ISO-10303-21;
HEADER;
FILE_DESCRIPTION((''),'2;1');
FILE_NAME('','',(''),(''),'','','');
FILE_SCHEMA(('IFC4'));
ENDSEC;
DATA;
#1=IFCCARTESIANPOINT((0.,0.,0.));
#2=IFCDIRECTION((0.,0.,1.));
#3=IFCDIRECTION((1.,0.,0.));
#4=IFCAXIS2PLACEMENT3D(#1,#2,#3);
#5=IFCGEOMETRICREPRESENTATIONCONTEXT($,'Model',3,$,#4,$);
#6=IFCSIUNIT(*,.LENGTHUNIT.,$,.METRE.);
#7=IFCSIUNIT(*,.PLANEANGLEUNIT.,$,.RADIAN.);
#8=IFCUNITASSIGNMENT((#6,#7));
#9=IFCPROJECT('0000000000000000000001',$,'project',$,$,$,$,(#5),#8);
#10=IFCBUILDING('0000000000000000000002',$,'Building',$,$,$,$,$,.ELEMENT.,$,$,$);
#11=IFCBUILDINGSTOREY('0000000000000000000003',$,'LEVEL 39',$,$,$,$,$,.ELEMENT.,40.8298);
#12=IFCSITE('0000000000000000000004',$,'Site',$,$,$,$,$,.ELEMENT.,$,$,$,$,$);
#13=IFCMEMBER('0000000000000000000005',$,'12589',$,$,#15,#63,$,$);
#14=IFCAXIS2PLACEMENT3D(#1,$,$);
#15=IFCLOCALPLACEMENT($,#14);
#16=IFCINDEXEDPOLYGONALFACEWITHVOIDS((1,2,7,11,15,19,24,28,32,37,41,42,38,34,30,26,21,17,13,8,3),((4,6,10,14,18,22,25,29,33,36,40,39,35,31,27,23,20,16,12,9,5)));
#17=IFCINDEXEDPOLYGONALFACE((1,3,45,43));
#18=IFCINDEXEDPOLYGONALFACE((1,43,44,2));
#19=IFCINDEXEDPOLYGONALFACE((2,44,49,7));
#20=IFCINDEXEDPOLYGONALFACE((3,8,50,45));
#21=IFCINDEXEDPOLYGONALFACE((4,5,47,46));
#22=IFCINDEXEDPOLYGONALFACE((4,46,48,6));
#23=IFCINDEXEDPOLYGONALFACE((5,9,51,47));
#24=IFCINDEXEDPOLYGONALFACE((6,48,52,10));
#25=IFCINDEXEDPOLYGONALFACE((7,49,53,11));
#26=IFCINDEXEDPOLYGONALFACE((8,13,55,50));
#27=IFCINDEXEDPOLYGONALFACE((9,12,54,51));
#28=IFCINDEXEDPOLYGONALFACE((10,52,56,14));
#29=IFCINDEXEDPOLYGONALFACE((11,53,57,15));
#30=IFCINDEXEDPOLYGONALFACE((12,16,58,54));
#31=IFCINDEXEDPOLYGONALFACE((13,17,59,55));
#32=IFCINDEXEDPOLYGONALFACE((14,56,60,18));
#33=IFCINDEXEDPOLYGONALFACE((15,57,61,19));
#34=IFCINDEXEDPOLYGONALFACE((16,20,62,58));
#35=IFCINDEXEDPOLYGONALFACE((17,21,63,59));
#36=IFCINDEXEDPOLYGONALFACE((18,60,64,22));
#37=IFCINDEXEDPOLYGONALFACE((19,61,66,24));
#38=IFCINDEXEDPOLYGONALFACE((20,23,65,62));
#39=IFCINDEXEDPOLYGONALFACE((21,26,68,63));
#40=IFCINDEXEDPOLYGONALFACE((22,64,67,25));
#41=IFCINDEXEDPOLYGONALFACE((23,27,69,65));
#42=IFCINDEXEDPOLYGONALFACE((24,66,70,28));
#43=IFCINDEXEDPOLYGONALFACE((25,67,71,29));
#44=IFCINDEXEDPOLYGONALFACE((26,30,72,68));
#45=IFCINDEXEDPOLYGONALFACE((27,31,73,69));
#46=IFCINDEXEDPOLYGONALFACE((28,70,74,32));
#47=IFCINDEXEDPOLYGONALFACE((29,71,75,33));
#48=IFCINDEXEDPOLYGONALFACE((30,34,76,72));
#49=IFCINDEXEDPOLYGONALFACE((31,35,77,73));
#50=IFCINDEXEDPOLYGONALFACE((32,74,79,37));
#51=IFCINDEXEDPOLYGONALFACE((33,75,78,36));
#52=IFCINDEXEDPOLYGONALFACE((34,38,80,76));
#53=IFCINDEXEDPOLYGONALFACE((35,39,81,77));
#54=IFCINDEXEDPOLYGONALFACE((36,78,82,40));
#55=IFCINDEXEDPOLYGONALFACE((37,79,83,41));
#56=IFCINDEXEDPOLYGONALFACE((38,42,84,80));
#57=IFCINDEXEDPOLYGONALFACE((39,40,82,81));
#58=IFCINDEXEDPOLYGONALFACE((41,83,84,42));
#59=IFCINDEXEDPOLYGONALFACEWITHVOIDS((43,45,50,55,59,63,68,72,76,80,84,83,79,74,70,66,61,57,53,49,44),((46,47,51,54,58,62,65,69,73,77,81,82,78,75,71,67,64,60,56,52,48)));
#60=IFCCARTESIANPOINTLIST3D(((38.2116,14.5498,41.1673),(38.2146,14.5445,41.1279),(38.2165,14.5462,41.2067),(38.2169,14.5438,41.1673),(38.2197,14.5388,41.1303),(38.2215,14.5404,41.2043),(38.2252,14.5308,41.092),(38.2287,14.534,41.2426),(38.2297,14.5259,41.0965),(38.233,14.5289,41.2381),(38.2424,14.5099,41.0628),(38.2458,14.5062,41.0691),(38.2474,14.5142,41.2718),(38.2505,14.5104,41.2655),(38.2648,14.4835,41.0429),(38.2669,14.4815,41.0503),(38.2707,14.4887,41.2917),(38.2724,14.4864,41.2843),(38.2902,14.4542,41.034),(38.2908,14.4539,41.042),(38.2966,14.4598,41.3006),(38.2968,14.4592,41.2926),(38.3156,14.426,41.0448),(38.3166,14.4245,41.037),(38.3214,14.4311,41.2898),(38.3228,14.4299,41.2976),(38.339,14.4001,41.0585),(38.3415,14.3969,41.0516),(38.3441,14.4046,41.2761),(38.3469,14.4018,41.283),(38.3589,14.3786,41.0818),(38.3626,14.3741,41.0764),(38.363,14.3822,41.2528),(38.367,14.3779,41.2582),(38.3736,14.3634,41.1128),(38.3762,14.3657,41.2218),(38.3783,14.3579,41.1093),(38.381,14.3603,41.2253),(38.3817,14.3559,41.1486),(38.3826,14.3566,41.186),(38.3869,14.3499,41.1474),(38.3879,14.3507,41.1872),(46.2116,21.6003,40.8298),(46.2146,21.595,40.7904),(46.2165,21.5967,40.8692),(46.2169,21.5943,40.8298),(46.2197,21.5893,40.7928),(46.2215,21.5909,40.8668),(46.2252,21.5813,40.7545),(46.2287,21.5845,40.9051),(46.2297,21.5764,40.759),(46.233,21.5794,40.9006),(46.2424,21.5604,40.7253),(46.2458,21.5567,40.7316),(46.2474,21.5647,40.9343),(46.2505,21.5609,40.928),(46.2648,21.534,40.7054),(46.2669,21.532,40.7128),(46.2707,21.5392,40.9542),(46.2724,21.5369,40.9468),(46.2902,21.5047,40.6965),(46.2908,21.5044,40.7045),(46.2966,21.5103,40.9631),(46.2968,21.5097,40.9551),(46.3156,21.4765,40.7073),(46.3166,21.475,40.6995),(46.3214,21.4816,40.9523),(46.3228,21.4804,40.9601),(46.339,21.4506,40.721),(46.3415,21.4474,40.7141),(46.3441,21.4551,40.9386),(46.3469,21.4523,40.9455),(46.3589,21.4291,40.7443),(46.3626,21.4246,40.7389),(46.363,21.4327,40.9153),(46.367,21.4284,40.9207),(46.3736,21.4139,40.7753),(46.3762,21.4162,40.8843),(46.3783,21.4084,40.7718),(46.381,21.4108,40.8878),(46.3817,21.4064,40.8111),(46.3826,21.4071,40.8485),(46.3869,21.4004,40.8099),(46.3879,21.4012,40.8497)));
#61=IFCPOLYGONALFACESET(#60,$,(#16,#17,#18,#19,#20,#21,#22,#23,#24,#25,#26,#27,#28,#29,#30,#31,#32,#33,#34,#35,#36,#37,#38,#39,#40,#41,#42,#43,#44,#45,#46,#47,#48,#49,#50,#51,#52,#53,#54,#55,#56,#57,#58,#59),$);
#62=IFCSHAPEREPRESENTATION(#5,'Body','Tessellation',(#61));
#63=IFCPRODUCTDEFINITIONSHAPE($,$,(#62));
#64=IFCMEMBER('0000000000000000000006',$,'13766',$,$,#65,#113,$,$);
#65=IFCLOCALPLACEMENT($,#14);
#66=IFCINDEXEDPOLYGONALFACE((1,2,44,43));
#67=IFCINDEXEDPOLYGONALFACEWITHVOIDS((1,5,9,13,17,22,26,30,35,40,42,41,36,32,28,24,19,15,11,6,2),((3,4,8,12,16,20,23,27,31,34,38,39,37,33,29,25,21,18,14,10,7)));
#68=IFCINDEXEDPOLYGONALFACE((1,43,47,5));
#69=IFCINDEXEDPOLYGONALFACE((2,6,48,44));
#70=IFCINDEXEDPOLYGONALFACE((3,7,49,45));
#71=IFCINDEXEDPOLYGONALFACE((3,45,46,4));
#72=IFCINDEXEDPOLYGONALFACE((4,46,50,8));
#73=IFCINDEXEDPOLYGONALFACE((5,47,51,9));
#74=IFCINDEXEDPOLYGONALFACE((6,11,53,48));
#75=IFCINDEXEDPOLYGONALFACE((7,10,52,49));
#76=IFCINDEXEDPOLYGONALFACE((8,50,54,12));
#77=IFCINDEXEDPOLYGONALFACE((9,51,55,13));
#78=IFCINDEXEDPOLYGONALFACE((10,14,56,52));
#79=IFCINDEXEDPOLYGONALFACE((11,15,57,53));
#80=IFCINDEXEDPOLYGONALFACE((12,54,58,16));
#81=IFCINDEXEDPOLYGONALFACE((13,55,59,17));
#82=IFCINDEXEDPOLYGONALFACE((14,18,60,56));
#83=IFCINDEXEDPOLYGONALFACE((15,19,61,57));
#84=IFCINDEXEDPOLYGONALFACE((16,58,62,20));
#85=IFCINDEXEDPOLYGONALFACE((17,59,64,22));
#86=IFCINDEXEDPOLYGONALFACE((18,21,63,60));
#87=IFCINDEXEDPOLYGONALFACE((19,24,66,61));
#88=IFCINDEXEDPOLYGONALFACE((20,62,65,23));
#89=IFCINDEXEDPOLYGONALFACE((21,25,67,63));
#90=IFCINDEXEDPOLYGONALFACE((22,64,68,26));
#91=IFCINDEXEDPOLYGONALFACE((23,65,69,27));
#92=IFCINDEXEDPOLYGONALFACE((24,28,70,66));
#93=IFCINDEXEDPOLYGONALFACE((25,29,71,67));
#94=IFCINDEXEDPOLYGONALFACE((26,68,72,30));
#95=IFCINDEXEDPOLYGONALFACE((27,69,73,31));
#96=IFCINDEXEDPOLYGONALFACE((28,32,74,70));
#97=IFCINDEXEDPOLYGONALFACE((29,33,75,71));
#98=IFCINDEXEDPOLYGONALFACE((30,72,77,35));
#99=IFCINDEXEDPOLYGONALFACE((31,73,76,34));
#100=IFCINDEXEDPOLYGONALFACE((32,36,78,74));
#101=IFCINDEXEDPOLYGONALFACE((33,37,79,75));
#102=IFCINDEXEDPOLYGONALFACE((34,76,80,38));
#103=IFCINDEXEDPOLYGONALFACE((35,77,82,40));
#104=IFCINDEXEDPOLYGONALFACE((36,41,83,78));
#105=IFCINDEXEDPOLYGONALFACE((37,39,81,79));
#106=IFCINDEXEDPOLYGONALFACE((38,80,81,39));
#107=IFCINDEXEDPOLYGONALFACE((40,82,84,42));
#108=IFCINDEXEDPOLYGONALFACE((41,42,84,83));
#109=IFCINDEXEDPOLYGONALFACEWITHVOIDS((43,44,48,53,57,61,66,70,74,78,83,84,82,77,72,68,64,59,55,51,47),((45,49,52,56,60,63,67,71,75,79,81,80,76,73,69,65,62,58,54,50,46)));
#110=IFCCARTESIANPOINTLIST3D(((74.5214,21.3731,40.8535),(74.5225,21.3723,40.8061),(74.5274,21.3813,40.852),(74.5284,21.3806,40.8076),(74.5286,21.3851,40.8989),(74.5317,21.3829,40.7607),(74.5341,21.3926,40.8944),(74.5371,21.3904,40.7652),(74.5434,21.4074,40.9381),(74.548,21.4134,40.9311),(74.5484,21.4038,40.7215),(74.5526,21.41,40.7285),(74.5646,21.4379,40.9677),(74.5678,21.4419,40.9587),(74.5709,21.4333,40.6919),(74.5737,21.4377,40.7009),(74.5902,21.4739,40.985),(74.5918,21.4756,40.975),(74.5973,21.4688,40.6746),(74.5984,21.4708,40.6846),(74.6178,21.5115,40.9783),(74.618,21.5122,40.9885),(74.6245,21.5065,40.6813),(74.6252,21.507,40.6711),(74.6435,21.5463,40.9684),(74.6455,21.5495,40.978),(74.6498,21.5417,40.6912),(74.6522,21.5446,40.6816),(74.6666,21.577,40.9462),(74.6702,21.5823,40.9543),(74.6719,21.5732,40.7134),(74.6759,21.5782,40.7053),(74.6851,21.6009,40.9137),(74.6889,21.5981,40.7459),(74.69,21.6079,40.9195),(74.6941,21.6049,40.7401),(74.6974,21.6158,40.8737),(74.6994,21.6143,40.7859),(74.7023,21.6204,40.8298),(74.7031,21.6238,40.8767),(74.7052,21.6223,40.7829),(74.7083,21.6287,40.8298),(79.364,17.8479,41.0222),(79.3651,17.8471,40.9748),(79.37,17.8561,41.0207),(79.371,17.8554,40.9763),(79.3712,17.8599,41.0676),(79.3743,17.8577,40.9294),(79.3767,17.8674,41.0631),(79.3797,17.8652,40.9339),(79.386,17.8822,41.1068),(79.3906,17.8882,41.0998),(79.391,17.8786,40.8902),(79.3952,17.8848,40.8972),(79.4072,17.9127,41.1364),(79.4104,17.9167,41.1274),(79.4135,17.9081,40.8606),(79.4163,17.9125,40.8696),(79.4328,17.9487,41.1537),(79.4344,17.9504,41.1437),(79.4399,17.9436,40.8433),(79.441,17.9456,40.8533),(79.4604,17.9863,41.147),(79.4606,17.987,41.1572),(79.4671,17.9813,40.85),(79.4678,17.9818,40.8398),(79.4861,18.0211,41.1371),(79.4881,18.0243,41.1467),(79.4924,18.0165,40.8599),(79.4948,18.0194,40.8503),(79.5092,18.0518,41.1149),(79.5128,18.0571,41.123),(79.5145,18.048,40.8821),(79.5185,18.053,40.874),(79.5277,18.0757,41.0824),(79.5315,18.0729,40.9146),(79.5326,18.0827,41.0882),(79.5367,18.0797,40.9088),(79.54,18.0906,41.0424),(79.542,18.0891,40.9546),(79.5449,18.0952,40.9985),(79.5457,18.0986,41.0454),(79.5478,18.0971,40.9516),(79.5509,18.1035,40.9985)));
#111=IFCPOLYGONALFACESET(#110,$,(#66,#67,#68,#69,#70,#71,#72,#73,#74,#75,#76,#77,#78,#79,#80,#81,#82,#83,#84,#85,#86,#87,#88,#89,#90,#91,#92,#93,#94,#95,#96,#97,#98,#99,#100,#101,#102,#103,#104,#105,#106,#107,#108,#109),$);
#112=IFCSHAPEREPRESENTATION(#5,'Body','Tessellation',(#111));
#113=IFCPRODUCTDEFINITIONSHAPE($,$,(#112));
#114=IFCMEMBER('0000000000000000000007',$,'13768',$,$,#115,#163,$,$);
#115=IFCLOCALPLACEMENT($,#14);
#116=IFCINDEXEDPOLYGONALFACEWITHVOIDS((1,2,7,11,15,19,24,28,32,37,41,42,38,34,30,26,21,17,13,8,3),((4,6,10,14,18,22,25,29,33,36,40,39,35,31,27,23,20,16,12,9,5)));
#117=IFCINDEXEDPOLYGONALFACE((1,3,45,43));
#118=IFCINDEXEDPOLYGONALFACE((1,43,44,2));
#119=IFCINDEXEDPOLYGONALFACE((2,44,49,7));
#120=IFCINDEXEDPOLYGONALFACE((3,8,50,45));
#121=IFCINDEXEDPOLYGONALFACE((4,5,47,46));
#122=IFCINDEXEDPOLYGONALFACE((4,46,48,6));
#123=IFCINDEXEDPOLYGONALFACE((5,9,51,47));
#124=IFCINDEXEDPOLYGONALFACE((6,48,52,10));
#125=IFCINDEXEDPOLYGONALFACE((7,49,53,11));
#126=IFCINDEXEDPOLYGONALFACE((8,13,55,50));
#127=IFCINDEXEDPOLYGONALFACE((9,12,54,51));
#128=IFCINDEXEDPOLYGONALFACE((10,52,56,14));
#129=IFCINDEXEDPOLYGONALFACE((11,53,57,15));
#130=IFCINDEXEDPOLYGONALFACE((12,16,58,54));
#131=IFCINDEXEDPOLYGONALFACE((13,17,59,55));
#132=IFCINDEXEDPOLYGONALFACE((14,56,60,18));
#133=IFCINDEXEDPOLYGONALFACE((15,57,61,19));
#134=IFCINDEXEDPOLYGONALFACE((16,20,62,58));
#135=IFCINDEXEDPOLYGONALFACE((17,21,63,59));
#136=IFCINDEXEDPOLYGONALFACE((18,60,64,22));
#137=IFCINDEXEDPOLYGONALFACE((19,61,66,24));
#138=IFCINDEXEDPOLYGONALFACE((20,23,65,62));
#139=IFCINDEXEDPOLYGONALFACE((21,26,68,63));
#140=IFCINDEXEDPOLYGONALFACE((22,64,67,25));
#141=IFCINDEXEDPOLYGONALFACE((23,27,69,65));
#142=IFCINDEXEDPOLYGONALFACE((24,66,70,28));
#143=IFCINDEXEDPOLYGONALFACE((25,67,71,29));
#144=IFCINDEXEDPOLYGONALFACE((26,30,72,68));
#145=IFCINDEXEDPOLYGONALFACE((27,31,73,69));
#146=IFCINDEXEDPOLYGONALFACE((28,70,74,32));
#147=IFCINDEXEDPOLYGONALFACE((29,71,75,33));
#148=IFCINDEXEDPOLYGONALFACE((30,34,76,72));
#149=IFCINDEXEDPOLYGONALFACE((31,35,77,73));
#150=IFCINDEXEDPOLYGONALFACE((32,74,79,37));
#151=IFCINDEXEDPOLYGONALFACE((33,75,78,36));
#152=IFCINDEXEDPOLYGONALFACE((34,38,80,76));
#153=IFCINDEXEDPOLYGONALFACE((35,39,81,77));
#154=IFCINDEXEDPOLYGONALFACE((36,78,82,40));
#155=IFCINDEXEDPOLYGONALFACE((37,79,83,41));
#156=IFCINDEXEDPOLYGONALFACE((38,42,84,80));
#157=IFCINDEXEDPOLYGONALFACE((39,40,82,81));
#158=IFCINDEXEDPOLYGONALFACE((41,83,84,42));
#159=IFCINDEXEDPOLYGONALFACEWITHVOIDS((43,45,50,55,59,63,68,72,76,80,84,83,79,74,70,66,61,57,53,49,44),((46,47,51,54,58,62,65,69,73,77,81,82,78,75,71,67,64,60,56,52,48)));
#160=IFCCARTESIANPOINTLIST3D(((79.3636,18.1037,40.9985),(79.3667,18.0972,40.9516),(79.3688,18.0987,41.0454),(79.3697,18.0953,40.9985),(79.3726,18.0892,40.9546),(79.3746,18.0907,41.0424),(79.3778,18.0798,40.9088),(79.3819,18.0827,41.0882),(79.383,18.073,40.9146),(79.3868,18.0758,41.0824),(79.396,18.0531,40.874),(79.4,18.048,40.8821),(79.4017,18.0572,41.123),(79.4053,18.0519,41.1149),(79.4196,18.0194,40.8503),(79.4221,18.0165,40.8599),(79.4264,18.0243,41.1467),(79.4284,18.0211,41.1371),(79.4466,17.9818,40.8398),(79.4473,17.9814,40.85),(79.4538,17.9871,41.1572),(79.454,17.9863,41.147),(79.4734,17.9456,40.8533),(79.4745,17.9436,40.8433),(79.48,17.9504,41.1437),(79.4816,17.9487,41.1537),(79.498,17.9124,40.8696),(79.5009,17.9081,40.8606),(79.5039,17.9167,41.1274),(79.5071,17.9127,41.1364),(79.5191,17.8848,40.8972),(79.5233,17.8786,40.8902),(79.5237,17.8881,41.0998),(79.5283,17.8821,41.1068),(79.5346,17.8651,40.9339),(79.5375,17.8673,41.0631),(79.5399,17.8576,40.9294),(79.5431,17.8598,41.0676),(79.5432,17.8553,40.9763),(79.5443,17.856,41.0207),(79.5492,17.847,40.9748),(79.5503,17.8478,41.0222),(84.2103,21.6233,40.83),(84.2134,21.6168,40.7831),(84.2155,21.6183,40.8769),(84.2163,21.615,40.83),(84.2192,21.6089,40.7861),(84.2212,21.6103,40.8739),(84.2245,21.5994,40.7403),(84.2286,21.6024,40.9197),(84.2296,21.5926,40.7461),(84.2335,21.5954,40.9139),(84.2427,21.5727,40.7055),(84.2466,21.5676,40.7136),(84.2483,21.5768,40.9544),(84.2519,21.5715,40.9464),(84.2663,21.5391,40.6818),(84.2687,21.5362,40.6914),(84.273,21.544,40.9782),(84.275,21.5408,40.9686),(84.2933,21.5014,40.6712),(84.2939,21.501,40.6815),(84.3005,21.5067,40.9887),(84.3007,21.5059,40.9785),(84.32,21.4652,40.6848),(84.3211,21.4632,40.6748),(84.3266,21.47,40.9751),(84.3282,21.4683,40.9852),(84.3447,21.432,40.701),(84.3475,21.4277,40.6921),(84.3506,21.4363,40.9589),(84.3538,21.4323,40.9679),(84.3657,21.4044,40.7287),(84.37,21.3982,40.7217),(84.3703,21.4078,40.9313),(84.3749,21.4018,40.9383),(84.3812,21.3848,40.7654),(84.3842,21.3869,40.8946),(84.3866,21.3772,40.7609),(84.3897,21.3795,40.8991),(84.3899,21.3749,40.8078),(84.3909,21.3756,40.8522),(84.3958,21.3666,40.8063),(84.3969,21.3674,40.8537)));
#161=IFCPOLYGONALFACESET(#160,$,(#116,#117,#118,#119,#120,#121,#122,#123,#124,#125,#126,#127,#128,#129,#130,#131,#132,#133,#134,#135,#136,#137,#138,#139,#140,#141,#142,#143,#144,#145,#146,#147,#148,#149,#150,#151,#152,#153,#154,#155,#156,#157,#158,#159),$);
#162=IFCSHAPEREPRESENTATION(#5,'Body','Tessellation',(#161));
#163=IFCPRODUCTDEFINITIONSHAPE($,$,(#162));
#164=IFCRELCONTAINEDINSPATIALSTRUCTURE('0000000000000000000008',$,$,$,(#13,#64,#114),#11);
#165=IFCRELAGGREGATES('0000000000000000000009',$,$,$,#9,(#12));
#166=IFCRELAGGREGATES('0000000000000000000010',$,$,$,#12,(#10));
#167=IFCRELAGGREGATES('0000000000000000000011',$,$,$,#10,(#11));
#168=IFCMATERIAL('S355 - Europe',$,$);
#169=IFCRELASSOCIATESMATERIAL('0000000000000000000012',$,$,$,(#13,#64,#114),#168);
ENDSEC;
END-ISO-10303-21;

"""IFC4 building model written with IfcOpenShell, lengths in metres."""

from ifc_helpers import new_model, si_unit, frame, origin_with_axes, origin_2d_with_axis, place, context, project, spatial, hollow_circle, extrude, material, material_profile, profile_set, profile_usage, element, save


model = new_model("IFC4")

# Units and contexts
model_context = context("Model", 3, world=origin_with_axes())
ifc_project = project(units=[si_unit("LENGTHUNIT", "METRE"), si_unit("PLANEANGLEUNIT", "RADIAN")], contexts=[model_context])

# Site, building, storey
site = spatial("IfcSite", under=ifc_project, Name="Site", CompositionType="ELEMENT")
building = spatial("IfcBuilding", under=site, Name="Building", CompositionType="ELEMENT")
storey = spatial("IfcBuildingStorey", under=building, Name="LEVEL 39", CompositionType="ELEMENT", Elevation=40.8298)

# Shared definitions
ifc_material = material(Name="S355 - Europe")

# Members
ifc_material_profile_1 = material_profile(ifc_material, hollow_circle(Radius=0.1337, WallThickness=0.008, at=origin_2d_with_axis()))
ifc_profile_set_1 = profile_set([ifc_material_profile_1])
ifc_profile_usage_1 = profile_usage(ifc_profile_set_1, cardinal=10)
member_1_placement = place(None, frame((38.3, 14.4495, 41.1673), z_axis=(0.749849, 0.660852, -0.031634), x_axis=(-0.661183, 0.750225, 0.0)))
element("IfcMember", 1, at=member_1_placement, inside=storey, material=ifc_profile_usage_1, Name="12589", context=model_context, shape_type="SweptSolid", body=[
    extrude(hollow_circle(Radius=0.1337, WallThickness=0.008, at=origin_2d_with_axis()), origin_with_axes(), (0.0, 0.0, 1.0), 10.6688),
])
ifc_material_profile_2 = material_profile(ifc_material, hollow_circle(Radius=0.1593, WallThickness=0.0103, at=origin_2d_with_axis()))
ifc_profile_set_2 = profile_set([ifc_material_profile_2])
ifc_profile_usage_2 = profile_usage(ifc_profile_set_2, cardinal=10)
member_2_placement = place(None, frame((74.6146, 21.5, 40.8298), z_axis=(0.808153, -0.5883, 0.028153), x_axis=(0.587676, 0.809096, 0.0)))
element("IfcMember", 2, at=member_2_placement, inside=storey, material=ifc_profile_usage_2, Name="13766", context=model_context, shape_type="SweptSolid", body=[
    extrude(hollow_circle(Radius=0.1593, WallThickness=0.0103, at=origin_2d_with_axis()), origin_with_axes(), (0.0, 0.0, 1.0), 5.9922),
])
ifc_material_profile_3 = material_profile(ifc_material, hollow_circle(Radius=0.1593, WallThickness=0.0103, at=origin_2d_with_axis()))
ifc_profile_set_3 = profile_set([ifc_material_profile_3])
ifc_profile_usage_3 = profile_usage(ifc_profile_set_3, cardinal=10)
member_3_placement = place(None, frame((79.4572, 17.9748, 40.9985), z_axis=(0.80883, 0.58737, -0.028122), x_axis=(-0.587929, 0.808912, 0.0)))
element("IfcMember", 3, at=member_3_placement, inside=storey, material=ifc_profile_usage_3, Name="13768", context=model_context, shape_type="SweptSolid", body=[
    extrude(hollow_circle(Radius=0.1593, WallThickness=0.0103, at=origin_2d_with_axis()), origin_with_axes(), (0.0, 0.0, 1.0), 5.9922),
])

save(model, "model.ifc")
